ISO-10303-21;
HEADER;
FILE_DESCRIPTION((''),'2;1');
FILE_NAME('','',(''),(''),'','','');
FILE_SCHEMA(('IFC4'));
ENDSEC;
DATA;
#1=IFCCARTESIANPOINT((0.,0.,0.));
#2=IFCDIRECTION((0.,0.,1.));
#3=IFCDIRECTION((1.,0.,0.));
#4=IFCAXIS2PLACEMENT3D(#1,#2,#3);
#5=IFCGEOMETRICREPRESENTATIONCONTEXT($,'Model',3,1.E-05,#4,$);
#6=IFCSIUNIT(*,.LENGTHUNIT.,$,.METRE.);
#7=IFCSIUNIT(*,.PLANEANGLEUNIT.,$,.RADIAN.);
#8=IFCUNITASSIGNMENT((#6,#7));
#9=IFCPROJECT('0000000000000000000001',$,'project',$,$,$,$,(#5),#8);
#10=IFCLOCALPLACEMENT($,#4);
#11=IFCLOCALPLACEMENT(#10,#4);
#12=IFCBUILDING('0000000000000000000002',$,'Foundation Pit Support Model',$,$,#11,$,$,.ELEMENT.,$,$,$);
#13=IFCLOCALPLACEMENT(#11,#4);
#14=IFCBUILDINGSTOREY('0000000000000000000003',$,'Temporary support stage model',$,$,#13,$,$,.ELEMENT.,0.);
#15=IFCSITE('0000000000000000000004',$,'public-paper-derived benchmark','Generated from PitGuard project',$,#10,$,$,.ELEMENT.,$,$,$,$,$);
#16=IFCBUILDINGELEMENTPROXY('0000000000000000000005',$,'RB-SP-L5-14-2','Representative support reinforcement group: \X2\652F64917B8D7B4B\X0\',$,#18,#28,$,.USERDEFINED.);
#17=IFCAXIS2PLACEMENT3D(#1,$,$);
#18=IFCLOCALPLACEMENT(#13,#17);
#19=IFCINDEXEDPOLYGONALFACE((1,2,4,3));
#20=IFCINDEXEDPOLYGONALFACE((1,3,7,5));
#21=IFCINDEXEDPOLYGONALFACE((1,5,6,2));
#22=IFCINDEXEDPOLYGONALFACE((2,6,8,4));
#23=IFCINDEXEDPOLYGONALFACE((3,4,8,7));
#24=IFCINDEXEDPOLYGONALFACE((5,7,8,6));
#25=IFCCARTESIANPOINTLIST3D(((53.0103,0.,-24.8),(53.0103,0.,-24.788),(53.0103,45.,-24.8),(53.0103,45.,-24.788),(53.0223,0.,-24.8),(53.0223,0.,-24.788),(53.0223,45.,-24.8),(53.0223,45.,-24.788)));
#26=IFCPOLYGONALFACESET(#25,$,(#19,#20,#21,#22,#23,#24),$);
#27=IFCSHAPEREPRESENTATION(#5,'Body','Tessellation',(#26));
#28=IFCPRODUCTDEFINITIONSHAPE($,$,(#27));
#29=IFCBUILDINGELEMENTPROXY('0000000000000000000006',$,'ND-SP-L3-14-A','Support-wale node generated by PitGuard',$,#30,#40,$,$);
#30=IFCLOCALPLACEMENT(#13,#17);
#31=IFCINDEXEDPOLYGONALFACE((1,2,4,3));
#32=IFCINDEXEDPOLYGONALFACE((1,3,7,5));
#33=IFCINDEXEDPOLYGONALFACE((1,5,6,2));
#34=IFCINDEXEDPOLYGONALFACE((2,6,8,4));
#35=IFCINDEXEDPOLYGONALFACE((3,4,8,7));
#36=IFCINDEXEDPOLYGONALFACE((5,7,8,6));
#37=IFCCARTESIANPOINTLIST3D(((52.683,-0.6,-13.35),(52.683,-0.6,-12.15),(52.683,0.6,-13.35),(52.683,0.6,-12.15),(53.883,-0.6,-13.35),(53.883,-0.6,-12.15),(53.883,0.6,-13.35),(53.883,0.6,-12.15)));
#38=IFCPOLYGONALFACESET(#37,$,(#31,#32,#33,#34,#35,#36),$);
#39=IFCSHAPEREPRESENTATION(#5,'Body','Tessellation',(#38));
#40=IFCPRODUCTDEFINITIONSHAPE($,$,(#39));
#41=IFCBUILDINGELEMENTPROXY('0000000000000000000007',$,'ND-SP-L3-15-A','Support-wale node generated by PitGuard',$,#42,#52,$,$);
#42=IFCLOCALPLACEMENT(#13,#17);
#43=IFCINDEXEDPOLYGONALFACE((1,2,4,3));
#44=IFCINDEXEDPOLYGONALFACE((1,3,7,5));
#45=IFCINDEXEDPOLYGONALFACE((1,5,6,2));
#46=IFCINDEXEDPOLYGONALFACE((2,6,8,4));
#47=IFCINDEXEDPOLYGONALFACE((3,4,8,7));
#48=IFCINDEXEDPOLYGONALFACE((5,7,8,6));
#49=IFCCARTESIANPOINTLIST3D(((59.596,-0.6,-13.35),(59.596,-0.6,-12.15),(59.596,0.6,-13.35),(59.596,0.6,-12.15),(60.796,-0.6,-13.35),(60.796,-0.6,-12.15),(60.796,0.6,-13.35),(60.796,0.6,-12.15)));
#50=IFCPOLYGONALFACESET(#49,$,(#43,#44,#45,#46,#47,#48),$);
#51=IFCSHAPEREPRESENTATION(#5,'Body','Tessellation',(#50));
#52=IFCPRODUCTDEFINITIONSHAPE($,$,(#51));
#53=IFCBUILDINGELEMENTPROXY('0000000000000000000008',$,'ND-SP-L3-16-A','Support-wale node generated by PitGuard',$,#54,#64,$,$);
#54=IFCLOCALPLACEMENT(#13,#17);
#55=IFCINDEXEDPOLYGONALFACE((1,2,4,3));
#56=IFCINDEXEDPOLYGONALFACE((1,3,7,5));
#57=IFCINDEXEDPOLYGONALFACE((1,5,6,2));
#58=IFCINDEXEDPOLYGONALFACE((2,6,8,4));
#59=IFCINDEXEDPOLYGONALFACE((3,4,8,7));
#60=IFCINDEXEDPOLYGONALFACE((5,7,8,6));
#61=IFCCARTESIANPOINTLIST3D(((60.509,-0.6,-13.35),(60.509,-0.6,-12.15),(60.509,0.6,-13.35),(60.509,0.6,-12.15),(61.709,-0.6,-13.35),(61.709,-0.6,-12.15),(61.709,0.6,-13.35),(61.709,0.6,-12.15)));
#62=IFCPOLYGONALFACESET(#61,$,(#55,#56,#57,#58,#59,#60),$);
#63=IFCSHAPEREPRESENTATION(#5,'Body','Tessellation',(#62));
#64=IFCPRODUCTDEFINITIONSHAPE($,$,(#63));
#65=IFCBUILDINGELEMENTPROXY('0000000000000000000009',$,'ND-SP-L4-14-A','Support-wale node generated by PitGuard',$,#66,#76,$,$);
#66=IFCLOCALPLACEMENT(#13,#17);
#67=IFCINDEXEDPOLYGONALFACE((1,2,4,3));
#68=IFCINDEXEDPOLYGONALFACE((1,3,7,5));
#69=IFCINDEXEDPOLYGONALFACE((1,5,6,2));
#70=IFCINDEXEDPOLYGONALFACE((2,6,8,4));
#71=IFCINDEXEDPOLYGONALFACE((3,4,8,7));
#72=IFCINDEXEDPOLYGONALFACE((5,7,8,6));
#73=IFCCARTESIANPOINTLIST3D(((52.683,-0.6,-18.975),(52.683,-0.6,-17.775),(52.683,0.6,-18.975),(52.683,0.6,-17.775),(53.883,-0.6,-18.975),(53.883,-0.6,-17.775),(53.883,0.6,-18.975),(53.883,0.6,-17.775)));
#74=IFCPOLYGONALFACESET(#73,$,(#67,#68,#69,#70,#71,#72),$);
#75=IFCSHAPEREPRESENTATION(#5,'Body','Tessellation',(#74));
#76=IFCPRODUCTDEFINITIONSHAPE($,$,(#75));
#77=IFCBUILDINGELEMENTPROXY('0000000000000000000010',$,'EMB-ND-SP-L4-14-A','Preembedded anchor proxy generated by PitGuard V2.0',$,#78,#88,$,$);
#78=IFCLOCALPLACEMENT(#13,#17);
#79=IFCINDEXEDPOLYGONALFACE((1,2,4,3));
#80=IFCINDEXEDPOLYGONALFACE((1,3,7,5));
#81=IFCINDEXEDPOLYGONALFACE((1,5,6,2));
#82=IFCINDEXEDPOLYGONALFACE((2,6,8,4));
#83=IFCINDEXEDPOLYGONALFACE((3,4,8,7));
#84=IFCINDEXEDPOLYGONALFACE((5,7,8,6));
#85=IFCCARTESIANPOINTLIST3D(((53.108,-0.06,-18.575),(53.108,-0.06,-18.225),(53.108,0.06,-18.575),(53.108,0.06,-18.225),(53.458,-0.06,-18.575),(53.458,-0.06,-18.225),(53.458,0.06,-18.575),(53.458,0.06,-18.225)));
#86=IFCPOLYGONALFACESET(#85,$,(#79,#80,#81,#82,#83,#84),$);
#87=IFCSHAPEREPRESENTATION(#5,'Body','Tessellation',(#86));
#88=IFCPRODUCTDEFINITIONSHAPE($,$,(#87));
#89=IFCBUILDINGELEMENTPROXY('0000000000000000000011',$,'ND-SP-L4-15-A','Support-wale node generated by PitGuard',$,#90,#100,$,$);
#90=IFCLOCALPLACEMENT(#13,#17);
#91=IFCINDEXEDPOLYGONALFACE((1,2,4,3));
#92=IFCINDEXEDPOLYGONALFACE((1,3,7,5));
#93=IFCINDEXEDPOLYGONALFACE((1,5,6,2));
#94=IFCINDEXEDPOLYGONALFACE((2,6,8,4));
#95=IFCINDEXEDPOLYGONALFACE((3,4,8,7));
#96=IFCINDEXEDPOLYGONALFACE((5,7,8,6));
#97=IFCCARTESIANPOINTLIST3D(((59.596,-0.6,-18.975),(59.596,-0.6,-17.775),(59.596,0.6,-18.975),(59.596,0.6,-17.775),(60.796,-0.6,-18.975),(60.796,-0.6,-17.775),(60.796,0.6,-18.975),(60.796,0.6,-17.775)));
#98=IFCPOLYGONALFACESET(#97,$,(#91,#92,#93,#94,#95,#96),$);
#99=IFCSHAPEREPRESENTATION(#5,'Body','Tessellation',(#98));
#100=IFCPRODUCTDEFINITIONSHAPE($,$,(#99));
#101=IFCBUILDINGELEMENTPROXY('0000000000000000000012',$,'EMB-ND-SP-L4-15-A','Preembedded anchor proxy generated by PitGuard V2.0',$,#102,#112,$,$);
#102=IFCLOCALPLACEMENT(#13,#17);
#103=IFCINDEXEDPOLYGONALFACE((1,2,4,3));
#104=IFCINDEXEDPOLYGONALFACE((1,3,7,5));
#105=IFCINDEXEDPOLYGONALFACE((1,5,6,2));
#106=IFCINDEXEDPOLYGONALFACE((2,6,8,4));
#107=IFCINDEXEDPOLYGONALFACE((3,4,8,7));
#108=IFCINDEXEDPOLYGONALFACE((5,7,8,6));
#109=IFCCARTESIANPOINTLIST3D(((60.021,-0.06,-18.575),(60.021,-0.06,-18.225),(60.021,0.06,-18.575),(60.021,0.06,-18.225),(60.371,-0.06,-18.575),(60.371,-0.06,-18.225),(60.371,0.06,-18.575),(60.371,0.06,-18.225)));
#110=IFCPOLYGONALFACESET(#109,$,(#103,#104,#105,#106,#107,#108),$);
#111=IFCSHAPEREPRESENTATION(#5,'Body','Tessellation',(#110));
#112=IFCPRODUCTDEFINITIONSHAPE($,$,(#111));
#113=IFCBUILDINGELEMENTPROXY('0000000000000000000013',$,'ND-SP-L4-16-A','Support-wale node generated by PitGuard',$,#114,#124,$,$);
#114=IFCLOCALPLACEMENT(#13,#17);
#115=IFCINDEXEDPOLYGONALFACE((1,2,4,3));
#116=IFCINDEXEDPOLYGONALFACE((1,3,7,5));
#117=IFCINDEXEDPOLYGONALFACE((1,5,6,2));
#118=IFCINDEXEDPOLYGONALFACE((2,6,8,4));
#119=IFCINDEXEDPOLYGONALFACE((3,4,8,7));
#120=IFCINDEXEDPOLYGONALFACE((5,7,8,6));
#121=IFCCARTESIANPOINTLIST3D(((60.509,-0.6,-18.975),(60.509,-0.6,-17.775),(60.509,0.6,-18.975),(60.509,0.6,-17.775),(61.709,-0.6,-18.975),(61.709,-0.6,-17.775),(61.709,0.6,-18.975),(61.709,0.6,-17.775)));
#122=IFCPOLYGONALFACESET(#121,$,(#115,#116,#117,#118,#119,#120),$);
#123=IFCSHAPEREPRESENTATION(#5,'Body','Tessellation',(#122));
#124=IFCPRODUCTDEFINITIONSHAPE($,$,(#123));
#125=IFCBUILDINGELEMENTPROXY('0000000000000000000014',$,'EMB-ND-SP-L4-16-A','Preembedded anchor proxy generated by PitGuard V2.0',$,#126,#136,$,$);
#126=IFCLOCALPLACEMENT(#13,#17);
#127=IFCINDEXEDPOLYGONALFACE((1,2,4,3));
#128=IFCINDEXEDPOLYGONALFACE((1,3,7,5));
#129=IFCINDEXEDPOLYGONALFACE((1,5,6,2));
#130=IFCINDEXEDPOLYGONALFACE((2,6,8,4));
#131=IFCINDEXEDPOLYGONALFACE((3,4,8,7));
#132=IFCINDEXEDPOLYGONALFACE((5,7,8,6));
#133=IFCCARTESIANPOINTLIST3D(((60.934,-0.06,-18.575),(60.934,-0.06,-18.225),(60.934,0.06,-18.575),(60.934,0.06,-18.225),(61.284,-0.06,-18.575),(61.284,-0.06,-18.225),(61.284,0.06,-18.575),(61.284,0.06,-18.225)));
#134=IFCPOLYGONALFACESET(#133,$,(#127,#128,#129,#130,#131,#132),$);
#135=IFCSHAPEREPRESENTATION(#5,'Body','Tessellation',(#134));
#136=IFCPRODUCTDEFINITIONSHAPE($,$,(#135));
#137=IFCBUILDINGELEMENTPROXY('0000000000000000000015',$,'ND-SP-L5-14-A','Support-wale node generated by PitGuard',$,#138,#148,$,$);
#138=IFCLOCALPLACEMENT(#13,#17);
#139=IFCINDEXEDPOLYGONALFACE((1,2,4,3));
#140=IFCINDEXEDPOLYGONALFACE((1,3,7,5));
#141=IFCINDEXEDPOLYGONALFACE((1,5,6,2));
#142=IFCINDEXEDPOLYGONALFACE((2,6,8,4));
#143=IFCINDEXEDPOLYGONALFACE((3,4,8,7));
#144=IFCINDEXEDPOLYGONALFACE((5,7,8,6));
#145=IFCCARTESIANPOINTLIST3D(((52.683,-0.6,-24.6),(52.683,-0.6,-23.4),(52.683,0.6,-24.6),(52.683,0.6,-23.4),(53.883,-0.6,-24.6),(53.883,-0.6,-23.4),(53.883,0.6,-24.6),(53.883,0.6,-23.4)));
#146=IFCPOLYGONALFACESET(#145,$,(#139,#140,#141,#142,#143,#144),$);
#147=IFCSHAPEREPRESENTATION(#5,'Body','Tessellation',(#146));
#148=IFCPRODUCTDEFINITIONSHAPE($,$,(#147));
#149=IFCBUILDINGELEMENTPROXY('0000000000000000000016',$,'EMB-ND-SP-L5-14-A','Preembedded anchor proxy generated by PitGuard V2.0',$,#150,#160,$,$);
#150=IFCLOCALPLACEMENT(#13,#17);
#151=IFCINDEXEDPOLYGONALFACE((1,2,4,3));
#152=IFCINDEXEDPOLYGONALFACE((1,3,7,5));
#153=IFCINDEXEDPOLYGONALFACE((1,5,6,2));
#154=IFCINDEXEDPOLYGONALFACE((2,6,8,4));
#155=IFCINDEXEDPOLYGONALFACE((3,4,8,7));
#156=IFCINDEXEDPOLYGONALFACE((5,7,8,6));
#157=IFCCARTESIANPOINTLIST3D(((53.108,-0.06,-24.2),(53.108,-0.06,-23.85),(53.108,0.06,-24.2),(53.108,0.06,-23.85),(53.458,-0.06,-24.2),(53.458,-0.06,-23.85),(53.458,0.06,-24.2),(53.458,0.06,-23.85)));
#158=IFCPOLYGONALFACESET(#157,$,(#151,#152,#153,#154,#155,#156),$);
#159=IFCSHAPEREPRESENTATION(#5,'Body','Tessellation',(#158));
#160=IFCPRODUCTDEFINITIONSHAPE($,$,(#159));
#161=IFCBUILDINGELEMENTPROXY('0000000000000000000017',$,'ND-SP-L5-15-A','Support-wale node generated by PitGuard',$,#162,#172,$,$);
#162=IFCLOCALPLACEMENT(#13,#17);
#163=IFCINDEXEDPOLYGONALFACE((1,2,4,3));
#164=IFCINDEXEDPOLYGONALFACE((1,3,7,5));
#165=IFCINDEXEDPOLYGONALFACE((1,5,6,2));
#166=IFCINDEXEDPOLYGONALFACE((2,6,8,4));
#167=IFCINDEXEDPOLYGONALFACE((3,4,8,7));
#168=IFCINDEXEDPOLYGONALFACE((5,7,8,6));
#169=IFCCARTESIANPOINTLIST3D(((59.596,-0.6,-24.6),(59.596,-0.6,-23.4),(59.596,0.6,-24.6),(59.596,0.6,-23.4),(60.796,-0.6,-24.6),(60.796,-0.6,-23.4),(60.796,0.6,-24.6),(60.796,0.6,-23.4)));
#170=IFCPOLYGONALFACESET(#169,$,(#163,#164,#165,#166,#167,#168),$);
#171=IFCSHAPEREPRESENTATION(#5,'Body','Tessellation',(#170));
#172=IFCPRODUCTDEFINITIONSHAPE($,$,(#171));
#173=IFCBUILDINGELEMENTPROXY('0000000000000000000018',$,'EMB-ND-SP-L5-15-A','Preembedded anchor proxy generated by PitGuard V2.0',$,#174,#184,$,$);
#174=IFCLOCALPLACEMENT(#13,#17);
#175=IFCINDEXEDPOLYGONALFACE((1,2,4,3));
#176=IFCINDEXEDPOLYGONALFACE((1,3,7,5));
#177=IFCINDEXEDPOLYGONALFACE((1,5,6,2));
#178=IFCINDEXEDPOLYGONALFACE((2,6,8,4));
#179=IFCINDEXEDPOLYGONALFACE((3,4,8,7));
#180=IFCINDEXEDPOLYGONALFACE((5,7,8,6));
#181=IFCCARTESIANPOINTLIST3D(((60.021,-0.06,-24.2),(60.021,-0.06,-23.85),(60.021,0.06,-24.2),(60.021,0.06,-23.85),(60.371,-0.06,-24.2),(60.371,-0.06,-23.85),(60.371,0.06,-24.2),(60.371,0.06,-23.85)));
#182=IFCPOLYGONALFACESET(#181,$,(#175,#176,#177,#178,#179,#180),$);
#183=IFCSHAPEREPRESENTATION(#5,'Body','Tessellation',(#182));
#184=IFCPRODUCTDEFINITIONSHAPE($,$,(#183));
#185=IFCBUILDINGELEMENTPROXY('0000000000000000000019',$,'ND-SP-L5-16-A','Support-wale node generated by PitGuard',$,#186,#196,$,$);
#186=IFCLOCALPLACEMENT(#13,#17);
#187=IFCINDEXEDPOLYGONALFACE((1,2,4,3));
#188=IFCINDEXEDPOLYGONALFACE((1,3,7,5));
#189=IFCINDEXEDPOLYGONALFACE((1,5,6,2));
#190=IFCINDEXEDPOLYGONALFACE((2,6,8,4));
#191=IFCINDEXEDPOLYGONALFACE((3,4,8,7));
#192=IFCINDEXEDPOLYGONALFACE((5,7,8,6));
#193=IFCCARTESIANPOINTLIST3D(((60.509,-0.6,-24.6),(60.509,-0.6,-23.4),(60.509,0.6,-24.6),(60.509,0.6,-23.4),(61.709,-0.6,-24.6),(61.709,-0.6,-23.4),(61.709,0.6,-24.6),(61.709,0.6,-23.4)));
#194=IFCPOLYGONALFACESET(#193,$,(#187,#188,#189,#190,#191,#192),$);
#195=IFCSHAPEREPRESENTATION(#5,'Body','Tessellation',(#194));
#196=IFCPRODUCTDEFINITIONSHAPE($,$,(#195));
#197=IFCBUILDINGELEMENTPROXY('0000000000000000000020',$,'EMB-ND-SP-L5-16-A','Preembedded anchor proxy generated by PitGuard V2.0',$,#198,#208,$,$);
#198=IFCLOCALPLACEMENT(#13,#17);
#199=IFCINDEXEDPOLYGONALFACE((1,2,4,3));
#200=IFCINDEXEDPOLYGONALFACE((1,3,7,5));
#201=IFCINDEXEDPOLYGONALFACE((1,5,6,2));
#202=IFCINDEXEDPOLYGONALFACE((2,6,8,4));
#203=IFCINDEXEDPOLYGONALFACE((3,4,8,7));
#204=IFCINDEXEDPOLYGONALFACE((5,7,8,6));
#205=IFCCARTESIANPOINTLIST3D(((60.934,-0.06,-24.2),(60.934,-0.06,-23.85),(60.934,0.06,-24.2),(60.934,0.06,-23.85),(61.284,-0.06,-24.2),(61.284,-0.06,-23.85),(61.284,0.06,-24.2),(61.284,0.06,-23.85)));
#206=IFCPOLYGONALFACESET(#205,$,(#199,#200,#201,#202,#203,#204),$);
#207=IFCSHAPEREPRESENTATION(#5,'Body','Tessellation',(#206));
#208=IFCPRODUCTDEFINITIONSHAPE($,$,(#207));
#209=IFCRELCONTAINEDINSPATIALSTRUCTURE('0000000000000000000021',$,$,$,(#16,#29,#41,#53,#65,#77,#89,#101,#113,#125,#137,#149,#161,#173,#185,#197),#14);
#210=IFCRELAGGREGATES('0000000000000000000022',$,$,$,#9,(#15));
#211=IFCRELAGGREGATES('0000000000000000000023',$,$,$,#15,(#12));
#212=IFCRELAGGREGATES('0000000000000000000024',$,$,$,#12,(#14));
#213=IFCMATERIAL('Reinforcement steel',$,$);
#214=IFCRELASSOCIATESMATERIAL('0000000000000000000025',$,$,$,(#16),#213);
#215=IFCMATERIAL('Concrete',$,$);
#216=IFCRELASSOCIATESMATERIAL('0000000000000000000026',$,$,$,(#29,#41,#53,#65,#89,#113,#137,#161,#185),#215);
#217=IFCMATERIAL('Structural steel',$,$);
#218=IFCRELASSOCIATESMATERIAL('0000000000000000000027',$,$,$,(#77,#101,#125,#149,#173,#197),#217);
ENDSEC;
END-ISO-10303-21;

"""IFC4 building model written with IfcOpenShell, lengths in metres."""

from ifc_helpers import new_model, si_unit, frame, origin_with_axes, origin_2d, place, context, project, spatial, rectangle, extrude, material, element, save


model = new_model("IFC4")

# Units and contexts
model_context = context("Model", 3, precision=1e-05, world=origin_with_axes())
ifc_project = project(units=[si_unit("LENGTHUNIT", "METRE"), si_unit("PLANEANGLEUNIT", "RADIAN")], contexts=[model_context])

# Site, building, storey
site_placement = place(None, origin_with_axes())
site = spatial("IfcSite", under=ifc_project, at=site_placement, Name="public-paper-derived benchmark", Description="Generated from PitGuard project", CompositionType="ELEMENT")
building_placement = place(site_placement, origin_with_axes())
building = spatial("IfcBuilding", under=site, at=building_placement, Name="Foundation Pit Support Model", CompositionType="ELEMENT")
storey_placement = place(building_placement, origin_with_axes())
storey = spatial("IfcBuildingStorey", under=building, at=storey_placement, Name="Temporary support stage model", CompositionType="ELEMENT", Elevation=0.0)

# Shared definitions
ifc_material_1 = material(Name="Structural steel")

# Shared definitions
ifc_material_2 = material(Name="Concrete")

# Building element proxies
ifc_material_3 = material(Name="Reinforcement steel")
proxy_1_placement = place(storey_placement, frame((53.0163, 22.5, -24.8), z_axis=(0.0, 0.0, 1.0), x_axis=(0.0, 1.0, 0.0)))
element("IfcBuildingElementProxy", 1, at=proxy_1_placement, inside=storey, material=ifc_material_3, Name="RB-SP-L5-14-2", Description="Representative support reinforcement group: 支撑箍筋", PredefinedType="USERDEFINED", context=model_context, shape_type="SweptSolid", body=[
    extrude(rectangle(XDim=45.0, YDim=0.012, at=origin_2d()), origin_with_axes(), (0.0, 0.0, 1.0), 0.012),
])
for number, where, z_axis, x_axis, name in (
    (2, (53.283, 0.0, -13.35), (0.0, 0.0, 1.0), (1.0, 0.0, 0.0), "ND-SP-L3-14-A"),
    (3, (60.196, 0.0, -13.35), (0.0, 0.0, 1.0), (1.0, 0.0, 0.0), "ND-SP-L3-15-A"),
    (4, (61.109, 0.0, -13.35), (0.0, 0.0, 1.0), (1.0, 0.0, 0.0), "ND-SP-L3-16-A"),
    (5, (53.283, 0.0, -18.975), (0.0, 0.0, 1.0), (1.0, 0.0, 0.0), "ND-SP-L4-14-A"),
):
    element("IfcBuildingElementProxy", number, at=place(storey_placement, frame(where, z_axis=z_axis, x_axis=x_axis)), inside=storey, material=ifc_material_2, Name=name, Description="Support-wale node generated by PitGuard", context=model_context, shape_type="SweptSolid", body=[
        extrude(rectangle(XDim=1.2, YDim=1.2, at=origin_2d()), origin_with_axes(), (0.0, 0.0, 1.0), 1.2),
    ])
proxy_2_placement = place(storey_placement, frame((53.283, 0.0, -18.575), z_axis=(0.0, 0.0, 1.0), x_axis=(1.0, 0.0, 0.0)))
element("IfcBuildingElementProxy", 6, at=proxy_2_placement, inside=storey, material=ifc_material_1, Name="EMB-ND-SP-L4-14-A", Description="Preembedded anchor proxy generated by PitGuard V2.0", context=model_context, shape_type="SweptSolid", body=[
    extrude(rectangle(XDim=0.35, YDim=0.12, at=origin_2d()), origin_with_axes(), (0.0, 0.0, 1.0), 0.35),
])
proxy_3_placement = place(storey_placement, frame((60.196, 0.0, -18.975), z_axis=(0.0, 0.0, 1.0), x_axis=(1.0, 0.0, 0.0)))
element("IfcBuildingElementProxy", 7, at=proxy_3_placement, inside=storey, material=ifc_material_2, Name="ND-SP-L4-15-A", Description="Support-wale node generated by PitGuard", context=model_context, shape_type="SweptSolid", body=[
    extrude(rectangle(XDim=1.2, YDim=1.2, at=origin_2d()), origin_with_axes(), (0.0, 0.0, 1.0), 1.2),
])
proxy_4_placement = place(storey_placement, frame((60.196, 0.0, -18.575), z_axis=(0.0, 0.0, 1.0), x_axis=(1.0, 0.0, 0.0)))
element("IfcBuildingElementProxy", 8, at=proxy_4_placement, inside=storey, material=ifc_material_1, Name="EMB-ND-SP-L4-15-A", Description="Preembedded anchor proxy generated by PitGuard V2.0", context=model_context, shape_type="SweptSolid", body=[
    extrude(rectangle(XDim=0.35, YDim=0.12, at=origin_2d()), origin_with_axes(), (0.0, 0.0, 1.0), 0.35),
])
proxy_5_placement = place(storey_placement, frame((61.109, 0.0, -18.975), z_axis=(0.0, 0.0, 1.0), x_axis=(1.0, 0.0, 0.0)))
element("IfcBuildingElementProxy", 9, at=proxy_5_placement, inside=storey, material=ifc_material_2, Name="ND-SP-L4-16-A", Description="Support-wale node generated by PitGuard", context=model_context, shape_type="SweptSolid", body=[
    extrude(rectangle(XDim=1.2, YDim=1.2, at=origin_2d()), origin_with_axes(), (0.0, 0.0, 1.0), 1.2),
])
proxy_6_placement = place(storey_placement, frame((61.109, 0.0, -18.575), z_axis=(0.0, 0.0, 1.0), x_axis=(1.0, 0.0, 0.0)))
element("IfcBuildingElementProxy", 10, at=proxy_6_placement, inside=storey, material=ifc_material_1, Name="EMB-ND-SP-L4-16-A", Description="Preembedded anchor proxy generated by PitGuard V2.0", context=model_context, shape_type="SweptSolid", body=[
    extrude(rectangle(XDim=0.35, YDim=0.12, at=origin_2d()), origin_with_axes(), (0.0, 0.0, 1.0), 0.35),
])
proxy_7_placement = place(storey_placement, frame((53.283, 0.0, -24.6), z_axis=(0.0, 0.0, 1.0), x_axis=(1.0, 0.0, 0.0)))
element("IfcBuildingElementProxy", 11, at=proxy_7_placement, inside=storey, material=ifc_material_2, Name="ND-SP-L5-14-A", Description="Support-wale node generated by PitGuard", context=model_context, shape_type="SweptSolid", body=[
    extrude(rectangle(XDim=1.2, YDim=1.2, at=origin_2d()), origin_with_axes(), (0.0, 0.0, 1.0), 1.2),
])
proxy_8_placement = place(storey_placement, frame((53.283, 0.0, -24.2), z_axis=(0.0, 0.0, 1.0), x_axis=(1.0, 0.0, 0.0)))
element("IfcBuildingElementProxy", 12, at=proxy_8_placement, inside=storey, material=ifc_material_1, Name="EMB-ND-SP-L5-14-A", Description="Preembedded anchor proxy generated by PitGuard V2.0", context=model_context, shape_type="SweptSolid", body=[
    extrude(rectangle(XDim=0.35, YDim=0.12, at=origin_2d()), origin_with_axes(), (0.0, 0.0, 1.0), 0.35),
])
proxy_9_placement = place(storey_placement, frame((60.196, 0.0, -24.6), z_axis=(0.0, 0.0, 1.0), x_axis=(1.0, 0.0, 0.0)))
element("IfcBuildingElementProxy", 13, at=proxy_9_placement, inside=storey, material=ifc_material_2, Name="ND-SP-L5-15-A", Description="Support-wale node generated by PitGuard", context=model_context, shape_type="SweptSolid", body=[
    extrude(rectangle(XDim=1.2, YDim=1.2, at=origin_2d()), origin_with_axes(), (0.0, 0.0, 1.0), 1.2),
])
proxy_10_placement = place(storey_placement, frame((60.196, 0.0, -24.2), z_axis=(0.0, 0.0, 1.0), x_axis=(1.0, 0.0, 0.0)))
element("IfcBuildingElementProxy", 14, at=proxy_10_placement, inside=storey, material=ifc_material_1, Name="EMB-ND-SP-L5-15-A", Description="Preembedded anchor proxy generated by PitGuard V2.0", context=model_context, shape_type="SweptSolid", body=[
    extrude(rectangle(XDim=0.35, YDim=0.12, at=origin_2d()), origin_with_axes(), (0.0, 0.0, 1.0), 0.35),
])
proxy_11_placement = place(storey_placement, frame((61.109, 0.0, -24.6), z_axis=(0.0, 0.0, 1.0), x_axis=(1.0, 0.0, 0.0)))
element("IfcBuildingElementProxy", 15, at=proxy_11_placement, inside=storey, material=ifc_material_2, Name="ND-SP-L5-16-A", Description="Support-wale node generated by PitGuard", context=model_context, shape_type="SweptSolid", body=[
    extrude(rectangle(XDim=1.2, YDim=1.2, at=origin_2d()), origin_with_axes(), (0.0, 0.0, 1.0), 1.2),
])
proxy_12_placement = place(storey_placement, frame((61.109, 0.0, -24.2), z_axis=(0.0, 0.0, 1.0), x_axis=(1.0, 0.0, 0.0)))
element("IfcBuildingElementProxy", 16, at=proxy_12_placement, inside=storey, material=ifc_material_1, Name="EMB-ND-SP-L5-16-A", Description="Preembedded anchor proxy generated by PitGuard V2.0", context=model_context, shape_type="SweptSolid", body=[
    extrude(rectangle(XDim=0.35, YDim=0.12, at=origin_2d()), origin_with_axes(), (0.0, 0.0, 1.0), 0.35),
])

save(model, "model.ifc")
